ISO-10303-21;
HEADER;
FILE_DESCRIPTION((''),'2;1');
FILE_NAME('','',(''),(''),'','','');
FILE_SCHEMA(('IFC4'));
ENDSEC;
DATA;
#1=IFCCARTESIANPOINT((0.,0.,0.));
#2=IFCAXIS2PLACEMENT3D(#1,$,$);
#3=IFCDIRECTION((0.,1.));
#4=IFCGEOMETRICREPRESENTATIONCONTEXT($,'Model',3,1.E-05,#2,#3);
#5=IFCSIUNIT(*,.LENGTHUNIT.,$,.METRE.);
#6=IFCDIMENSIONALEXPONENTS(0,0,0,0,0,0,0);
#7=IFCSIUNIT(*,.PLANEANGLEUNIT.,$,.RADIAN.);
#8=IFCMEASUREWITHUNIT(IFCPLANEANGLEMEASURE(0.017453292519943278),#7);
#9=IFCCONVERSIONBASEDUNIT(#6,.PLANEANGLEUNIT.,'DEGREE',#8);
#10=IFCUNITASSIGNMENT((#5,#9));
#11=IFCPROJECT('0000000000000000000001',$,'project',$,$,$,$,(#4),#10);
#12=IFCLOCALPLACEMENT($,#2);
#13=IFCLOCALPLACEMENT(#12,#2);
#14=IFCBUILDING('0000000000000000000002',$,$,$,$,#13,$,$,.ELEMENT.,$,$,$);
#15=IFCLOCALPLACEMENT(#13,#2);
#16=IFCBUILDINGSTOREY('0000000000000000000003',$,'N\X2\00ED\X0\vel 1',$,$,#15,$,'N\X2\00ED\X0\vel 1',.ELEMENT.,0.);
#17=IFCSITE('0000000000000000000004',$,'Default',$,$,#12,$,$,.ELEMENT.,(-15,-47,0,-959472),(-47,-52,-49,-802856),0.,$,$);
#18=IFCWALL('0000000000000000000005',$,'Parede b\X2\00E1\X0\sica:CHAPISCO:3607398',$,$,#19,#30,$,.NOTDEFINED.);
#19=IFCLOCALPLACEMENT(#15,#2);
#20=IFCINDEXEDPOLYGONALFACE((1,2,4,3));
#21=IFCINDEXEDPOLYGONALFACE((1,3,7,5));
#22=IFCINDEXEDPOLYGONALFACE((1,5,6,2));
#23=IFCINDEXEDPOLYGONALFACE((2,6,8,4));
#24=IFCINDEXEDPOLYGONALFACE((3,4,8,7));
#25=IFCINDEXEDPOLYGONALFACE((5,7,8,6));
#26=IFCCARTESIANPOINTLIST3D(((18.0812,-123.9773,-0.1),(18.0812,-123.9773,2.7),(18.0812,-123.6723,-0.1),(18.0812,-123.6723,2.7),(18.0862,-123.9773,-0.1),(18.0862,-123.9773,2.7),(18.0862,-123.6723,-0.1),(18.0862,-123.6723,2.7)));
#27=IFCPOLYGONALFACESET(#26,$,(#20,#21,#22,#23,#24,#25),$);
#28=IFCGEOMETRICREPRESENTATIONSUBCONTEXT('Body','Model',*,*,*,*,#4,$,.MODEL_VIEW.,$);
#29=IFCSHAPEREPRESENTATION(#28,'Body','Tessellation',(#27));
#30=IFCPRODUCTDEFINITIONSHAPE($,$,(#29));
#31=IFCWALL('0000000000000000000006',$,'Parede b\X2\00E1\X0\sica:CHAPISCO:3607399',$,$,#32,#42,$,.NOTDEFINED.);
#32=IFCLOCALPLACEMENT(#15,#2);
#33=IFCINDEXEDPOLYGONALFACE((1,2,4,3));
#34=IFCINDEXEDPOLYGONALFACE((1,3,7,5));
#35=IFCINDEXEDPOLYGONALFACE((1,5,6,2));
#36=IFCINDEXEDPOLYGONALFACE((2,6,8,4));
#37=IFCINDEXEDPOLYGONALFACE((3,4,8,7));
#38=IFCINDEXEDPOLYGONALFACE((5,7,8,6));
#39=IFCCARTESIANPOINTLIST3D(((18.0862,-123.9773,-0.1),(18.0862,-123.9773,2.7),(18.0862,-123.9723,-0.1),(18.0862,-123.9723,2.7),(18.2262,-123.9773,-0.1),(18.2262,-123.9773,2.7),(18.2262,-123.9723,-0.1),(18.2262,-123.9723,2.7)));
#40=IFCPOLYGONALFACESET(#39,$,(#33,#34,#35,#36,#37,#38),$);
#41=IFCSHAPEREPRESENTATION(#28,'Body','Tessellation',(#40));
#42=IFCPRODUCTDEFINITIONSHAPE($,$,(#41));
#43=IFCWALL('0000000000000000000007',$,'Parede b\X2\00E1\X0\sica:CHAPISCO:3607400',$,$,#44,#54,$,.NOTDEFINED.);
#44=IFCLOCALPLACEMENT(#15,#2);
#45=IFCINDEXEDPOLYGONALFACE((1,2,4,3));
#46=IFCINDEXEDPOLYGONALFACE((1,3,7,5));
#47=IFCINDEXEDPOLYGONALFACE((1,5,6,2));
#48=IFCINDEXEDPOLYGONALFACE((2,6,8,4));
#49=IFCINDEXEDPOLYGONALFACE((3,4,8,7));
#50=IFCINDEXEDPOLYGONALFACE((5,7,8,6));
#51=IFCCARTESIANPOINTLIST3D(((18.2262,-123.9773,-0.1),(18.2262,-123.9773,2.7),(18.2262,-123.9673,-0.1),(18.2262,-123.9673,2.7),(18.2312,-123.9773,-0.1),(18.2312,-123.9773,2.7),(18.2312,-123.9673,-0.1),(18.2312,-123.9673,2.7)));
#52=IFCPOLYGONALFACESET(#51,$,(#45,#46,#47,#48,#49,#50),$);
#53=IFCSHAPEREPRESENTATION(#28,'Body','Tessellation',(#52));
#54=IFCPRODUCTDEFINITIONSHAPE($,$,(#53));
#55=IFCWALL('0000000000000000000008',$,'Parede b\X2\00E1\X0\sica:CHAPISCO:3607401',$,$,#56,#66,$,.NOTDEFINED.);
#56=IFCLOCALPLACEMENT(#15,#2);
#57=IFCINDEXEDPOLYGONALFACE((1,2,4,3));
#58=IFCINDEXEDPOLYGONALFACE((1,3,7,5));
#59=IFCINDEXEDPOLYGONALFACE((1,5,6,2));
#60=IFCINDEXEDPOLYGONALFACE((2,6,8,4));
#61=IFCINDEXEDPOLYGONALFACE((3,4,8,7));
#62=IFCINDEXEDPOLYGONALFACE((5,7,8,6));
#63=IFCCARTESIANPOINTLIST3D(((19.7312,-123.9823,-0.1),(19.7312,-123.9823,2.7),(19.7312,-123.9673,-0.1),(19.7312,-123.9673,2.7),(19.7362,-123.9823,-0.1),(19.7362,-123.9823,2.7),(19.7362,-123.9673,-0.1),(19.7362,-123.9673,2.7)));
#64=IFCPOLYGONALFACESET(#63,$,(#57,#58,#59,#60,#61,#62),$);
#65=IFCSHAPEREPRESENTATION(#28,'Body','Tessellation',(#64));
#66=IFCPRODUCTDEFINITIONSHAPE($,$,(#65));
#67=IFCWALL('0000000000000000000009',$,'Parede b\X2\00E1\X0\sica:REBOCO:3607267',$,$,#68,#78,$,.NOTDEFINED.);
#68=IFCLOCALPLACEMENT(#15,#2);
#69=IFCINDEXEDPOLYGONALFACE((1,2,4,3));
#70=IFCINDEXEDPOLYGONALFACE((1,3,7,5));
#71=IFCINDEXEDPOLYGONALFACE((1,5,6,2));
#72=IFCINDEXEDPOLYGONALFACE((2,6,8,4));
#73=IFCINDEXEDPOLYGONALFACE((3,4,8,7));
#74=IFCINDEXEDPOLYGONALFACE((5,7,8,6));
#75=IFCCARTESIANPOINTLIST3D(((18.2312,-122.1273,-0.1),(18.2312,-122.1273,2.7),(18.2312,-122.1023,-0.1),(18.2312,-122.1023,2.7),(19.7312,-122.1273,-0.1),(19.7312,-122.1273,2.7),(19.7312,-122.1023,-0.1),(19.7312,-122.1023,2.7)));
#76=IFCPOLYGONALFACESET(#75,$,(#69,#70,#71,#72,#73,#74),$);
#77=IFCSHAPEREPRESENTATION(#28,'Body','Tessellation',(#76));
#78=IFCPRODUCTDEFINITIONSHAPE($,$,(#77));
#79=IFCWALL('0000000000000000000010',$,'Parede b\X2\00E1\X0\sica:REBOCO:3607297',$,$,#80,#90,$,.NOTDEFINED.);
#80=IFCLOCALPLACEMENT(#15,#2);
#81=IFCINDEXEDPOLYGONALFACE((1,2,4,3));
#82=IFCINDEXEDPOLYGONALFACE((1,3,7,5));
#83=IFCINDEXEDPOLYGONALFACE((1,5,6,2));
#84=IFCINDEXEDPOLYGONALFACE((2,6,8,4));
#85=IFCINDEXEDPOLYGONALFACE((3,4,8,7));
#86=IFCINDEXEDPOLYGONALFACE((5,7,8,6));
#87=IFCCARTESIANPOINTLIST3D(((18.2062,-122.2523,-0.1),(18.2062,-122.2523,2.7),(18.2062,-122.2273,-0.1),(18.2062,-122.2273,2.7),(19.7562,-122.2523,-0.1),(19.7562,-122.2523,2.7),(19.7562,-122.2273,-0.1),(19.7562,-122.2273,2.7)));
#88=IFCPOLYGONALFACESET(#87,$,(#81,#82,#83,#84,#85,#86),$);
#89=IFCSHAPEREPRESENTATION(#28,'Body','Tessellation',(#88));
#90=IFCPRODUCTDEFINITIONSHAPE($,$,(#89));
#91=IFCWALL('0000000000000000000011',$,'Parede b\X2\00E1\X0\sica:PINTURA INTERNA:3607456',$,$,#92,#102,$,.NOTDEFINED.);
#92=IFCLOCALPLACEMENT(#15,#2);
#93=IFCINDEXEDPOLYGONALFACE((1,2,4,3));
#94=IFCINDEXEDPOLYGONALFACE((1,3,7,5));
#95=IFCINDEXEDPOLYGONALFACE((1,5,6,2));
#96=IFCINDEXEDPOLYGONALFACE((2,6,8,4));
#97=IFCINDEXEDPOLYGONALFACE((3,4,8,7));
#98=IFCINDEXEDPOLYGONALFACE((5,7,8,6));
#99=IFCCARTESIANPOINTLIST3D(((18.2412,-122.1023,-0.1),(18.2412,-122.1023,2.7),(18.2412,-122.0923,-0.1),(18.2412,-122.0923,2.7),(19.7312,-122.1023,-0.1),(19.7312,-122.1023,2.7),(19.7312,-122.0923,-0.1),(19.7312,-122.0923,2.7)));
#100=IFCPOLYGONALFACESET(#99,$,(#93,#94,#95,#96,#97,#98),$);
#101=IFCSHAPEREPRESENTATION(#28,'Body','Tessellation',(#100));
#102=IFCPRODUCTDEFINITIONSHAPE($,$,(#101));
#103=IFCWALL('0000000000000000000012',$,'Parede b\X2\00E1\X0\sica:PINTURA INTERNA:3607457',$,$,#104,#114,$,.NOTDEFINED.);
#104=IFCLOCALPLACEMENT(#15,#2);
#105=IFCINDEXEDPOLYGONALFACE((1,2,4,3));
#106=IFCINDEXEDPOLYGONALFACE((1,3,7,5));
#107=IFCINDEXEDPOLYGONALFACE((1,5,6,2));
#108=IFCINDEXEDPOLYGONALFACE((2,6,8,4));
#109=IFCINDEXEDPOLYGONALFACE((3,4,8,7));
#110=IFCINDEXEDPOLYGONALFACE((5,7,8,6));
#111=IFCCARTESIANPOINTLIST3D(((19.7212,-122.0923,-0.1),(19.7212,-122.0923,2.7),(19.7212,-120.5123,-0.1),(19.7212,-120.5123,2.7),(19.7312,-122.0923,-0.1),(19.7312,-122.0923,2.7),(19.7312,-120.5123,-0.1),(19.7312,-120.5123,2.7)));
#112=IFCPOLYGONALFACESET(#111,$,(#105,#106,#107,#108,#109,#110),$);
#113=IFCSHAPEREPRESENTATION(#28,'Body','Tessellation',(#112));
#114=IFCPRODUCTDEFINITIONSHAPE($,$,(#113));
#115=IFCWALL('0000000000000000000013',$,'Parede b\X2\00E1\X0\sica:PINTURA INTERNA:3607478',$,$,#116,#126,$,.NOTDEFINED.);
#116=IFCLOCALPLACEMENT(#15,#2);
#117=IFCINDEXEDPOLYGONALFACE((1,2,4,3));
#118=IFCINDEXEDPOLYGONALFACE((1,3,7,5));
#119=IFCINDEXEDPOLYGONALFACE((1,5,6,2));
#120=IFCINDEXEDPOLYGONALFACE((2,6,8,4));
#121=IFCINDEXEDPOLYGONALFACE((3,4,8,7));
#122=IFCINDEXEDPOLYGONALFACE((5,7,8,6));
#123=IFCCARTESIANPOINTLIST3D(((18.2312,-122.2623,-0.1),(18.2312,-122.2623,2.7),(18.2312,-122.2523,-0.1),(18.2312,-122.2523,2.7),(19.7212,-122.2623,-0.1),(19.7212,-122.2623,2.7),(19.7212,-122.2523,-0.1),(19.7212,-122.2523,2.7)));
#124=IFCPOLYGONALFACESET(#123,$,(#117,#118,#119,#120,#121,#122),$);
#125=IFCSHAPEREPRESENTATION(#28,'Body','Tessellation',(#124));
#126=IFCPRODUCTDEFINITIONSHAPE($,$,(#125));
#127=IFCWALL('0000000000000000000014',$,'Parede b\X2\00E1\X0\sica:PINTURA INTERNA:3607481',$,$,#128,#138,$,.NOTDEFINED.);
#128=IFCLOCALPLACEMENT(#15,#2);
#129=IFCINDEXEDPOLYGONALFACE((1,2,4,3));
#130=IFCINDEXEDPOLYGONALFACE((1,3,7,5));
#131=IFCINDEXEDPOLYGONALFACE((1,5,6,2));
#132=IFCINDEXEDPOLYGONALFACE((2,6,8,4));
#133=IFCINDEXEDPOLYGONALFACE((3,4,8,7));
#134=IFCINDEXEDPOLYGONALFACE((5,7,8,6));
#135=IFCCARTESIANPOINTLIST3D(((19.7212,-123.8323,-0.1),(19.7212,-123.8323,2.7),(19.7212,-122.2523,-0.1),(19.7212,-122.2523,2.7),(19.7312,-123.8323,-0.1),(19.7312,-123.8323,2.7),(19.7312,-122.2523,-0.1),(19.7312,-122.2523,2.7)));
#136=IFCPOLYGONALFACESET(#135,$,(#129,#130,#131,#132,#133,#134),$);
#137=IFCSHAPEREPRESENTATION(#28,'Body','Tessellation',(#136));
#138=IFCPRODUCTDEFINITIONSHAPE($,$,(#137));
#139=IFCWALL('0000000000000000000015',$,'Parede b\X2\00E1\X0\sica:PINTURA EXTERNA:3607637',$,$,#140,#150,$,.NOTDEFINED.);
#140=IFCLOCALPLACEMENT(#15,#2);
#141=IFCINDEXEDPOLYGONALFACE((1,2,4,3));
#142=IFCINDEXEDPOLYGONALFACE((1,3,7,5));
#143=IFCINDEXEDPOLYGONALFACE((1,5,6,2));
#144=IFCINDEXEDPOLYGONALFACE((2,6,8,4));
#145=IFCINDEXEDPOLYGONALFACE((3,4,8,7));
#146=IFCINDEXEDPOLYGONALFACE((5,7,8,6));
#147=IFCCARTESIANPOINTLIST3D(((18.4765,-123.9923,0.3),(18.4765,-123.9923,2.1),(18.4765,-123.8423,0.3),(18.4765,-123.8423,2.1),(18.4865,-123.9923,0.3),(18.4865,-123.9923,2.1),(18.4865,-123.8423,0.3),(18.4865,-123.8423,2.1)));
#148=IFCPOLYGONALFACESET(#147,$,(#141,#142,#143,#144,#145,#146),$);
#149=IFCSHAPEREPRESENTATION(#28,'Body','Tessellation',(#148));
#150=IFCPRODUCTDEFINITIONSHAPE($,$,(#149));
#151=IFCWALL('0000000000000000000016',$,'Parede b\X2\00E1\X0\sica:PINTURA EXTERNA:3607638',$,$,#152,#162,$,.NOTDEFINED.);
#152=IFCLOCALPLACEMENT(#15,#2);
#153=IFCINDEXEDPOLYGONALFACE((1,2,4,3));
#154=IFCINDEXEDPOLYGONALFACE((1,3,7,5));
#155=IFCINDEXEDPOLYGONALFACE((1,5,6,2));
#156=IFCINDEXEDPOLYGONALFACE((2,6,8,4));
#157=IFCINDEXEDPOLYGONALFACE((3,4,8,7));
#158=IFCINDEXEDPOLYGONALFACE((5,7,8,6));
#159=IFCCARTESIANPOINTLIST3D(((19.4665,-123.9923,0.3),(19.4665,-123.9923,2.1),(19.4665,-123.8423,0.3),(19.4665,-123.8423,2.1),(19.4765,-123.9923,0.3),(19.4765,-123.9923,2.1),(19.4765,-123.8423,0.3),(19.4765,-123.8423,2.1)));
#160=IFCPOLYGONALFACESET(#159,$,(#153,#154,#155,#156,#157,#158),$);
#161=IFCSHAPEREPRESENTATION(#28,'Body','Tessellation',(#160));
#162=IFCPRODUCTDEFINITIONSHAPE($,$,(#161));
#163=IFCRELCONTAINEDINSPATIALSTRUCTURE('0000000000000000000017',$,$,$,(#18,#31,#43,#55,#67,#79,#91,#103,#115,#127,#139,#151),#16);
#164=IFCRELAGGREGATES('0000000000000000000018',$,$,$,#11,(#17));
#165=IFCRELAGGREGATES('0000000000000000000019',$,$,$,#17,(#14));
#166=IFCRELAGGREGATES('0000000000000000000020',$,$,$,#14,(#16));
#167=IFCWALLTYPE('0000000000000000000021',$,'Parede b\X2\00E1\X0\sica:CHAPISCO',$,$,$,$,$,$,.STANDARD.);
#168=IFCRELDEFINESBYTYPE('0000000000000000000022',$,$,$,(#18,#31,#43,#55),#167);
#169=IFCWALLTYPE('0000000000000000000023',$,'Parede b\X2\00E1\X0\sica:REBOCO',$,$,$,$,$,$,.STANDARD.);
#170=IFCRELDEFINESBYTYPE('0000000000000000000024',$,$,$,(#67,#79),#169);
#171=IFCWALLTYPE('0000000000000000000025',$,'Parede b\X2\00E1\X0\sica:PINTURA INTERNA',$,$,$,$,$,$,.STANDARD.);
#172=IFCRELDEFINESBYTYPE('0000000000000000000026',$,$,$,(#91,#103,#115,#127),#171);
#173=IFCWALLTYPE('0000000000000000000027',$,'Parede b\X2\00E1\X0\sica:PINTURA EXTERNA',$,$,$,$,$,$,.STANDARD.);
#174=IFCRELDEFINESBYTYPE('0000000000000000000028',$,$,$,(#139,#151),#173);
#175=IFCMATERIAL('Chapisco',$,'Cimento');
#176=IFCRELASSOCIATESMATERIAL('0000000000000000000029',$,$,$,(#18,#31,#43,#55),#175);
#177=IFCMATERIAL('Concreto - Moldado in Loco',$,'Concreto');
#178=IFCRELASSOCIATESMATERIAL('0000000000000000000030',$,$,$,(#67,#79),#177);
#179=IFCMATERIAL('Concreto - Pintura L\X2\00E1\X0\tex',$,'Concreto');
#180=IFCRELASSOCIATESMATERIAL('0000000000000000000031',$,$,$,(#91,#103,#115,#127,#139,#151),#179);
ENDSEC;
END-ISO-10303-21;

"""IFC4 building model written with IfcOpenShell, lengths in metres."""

from ifc_helpers import new_model, entity, si_unit, converted_unit, direction, frame, origin, place, context, subcontext, project, spatial, indexed_curve, outline, extrude, material, type_object, element, save


model = new_model("IFC4")

# Units and contexts
model_context = context("Model", 3, precision=1e-05, world=origin(), true_north=direction((0.0, 1.0)))
body_context = subcontext(model_context, "Body", "Model", "MODEL_VIEW")
ifc_project = project(units=[si_unit("LENGTHUNIT", "METRE"), converted_unit("PLANEANGLEUNIT", "DEGREE", entity("IfcPlaneAngleMeasure", 0.017453292519943278), si_unit("PLANEANGLEUNIT", "RADIAN"), dimensions=[0, 0, 0, 0, 0, 0, 0])], contexts=[model_context])

# Site, building, storey
site_placement = place(None, origin())
site = spatial("IfcSite", under=ifc_project, at=site_placement, Name="Default", CompositionType="ELEMENT", RefLatitude=(-15, -47, 0, -959472), RefLongitude=(-47, -52, -49, -802856), RefElevation=0.0)
building_placement = place(site_placement, origin())
building = spatial("IfcBuilding", under=site, at=building_placement, CompositionType="ELEMENT")
storey_placement = place(building_placement, origin())
storey = spatial("IfcBuildingStorey", under=building, at=storey_placement, Name="Nível 1", LongName="Nível 1", CompositionType="ELEMENT", Elevation=0.0)

# Walls
ifc_material_1 = material(Name="Chapisco", Category="Cimento")
wall_type_1 = type_object("IfcWallType", Name="Parede básica:CHAPISCO", PredefinedType="STANDARD")
wall_1_placement = place(storey_placement, frame((18.0837, -123.6723, -0.1), z_axis=(0.0, 0.0, 1.0), x_axis=(0.0, -1.0, 0.0)))
element("IfcWall", 1, at=wall_1_placement, inside=storey, type_object=wall_type_1, material=ifc_material_1, Name="Parede básica:CHAPISCO:3607398", PredefinedType="NOTDEFINED", context=body_context, shape_type="SweptSolid", body=[
    extrude(outline(indexed_curve([(0.305, 0.0025), (0.0, 0.0025), (0.0, -0.0025), (0.305, -0.0025), (0.305, 0.0025)], self_intersect=False)), origin(), (0.0, 0.0, 1.0), 2.8),
])
wall_2_placement = place(storey_placement, frame((18.0862, -123.9748, -0.1)))
element("IfcWall", 2, at=wall_2_placement, inside=storey, type_object=wall_type_1, material=ifc_material_1, Name="Parede básica:CHAPISCO:3607399", PredefinedType="NOTDEFINED", context=body_context, shape_type="SweptSolid", body=[
    extrude(outline(indexed_curve([(0.14, 0.0025), (0.0, 0.0025), (0.0, -0.0025), (0.14, -0.0025), (0.14, 0.0025)], self_intersect=False)), origin(), (0.0, 0.0, 1.0), 2.8),
])
wall_3_placement = place(storey_placement, frame((18.2287, -123.9773, -0.1), z_axis=(0.0, 0.0, 1.0), x_axis=(0.0, 1.0, 0.0)))
element("IfcWall", 3, at=wall_3_placement, inside=storey, type_object=wall_type_1, material=ifc_material_1, Name="Parede básica:CHAPISCO:3607400", PredefinedType="NOTDEFINED", context=body_context, shape_type="SweptSolid", body=[
    extrude(outline(indexed_curve([(0.01, 0.0025), (0.0, 0.0025), (0.0, -0.0025), (0.01, -0.0025), (0.01, 0.0025)], self_intersect=False)), origin(), (0.0, 0.0, 1.0), 2.8),
])
wall_4_placement = place(storey_placement, frame((19.7337, -123.9673, -0.1), z_axis=(0.0, 0.0, 1.0), x_axis=(0.0, -1.0, 0.0)))
element("IfcWall", 4, at=wall_4_placement, inside=storey, type_object=wall_type_1, material=ifc_material_1, Name="Parede básica:CHAPISCO:3607401", PredefinedType="NOTDEFINED", context=body_context, shape_type="SweptSolid", body=[
    extrude(outline(indexed_curve([(0.015, 0.0025), (0.0, 0.0025), (0.0, -0.0025), (0.015, -0.0025), (0.015, 0.0025)], self_intersect=False)), origin(), (0.0, 0.0, 1.0), 2.8),
])
ifc_material_2 = material(Name="Concreto - Moldado in Loco", Category="Concreto")
wall_type_2 = type_object("IfcWallType", Name="Parede básica:REBOCO", PredefinedType="STANDARD")
wall_5_placement = place(storey_placement, frame((19.7312, -122.1148, -0.1), z_axis=(0.0, 0.0, 1.0), x_axis=(-1.0, 0.0, 0.0)))
element("IfcWall", 5, at=wall_5_placement, inside=storey, type_object=wall_type_2, material=ifc_material_2, Name="Parede básica:REBOCO:3607267", PredefinedType="NOTDEFINED", context=body_context, shape_type="SweptSolid", body=[
    extrude(outline(indexed_curve([(1.5, 0.0125), (0.0, 0.0125), (0.0, -0.0125), (1.5, -0.0125), (1.5, 0.0125)], self_intersect=False)), origin(), (0.0, 0.0, 1.0), 2.8),
])
wall_6_placement = place(storey_placement, frame((18.2062, -122.2398, -0.1)))
element("IfcWall", 6, at=wall_6_placement, inside=storey, type_object=wall_type_2, material=ifc_material_2, Name="Parede básica:REBOCO:3607297", PredefinedType="NOTDEFINED", context=body_context, shape_type="SweptSolid", body=[
    extrude(outline(indexed_curve([(1.55, 0.0125), (0.0, 0.0125), (0.0, -0.0125), (1.55, -0.0125), (1.55, 0.0125)], self_intersect=False)), origin(), (0.0, 0.0, 1.0), 2.8),
])
ifc_material_3 = material(Name="Concreto - Pintura Látex", Category="Concreto")
wall_type_3 = type_object("IfcWallType", Name="Parede básica:PINTURA INTERNA", PredefinedType="STANDARD")
wall_7_placement = place(storey_placement, frame((19.7312, -122.0973, -0.1), z_axis=(0.0, 0.0, 1.0), x_axis=(-1.0, 0.0, 0.0)))
element("IfcWall", 7, at=wall_7_placement, inside=storey, type_object=wall_type_3, material=ifc_material_3, Name="Parede básica:PINTURA INTERNA:3607456", PredefinedType="NOTDEFINED", context=body_context, shape_type="SweptSolid", body=[
    extrude(outline(indexed_curve([(1.49, 0.005), (0.0, 0.005), (0.0, -0.005), (1.49, -0.005), (1.49, 0.005)], self_intersect=False)), origin(), (0.0, 0.0, 1.0), 2.8),
])
wall_8_placement = place(storey_placement, frame((19.7262, -120.5123, -0.1), z_axis=(0.0, 0.0, 1.0), x_axis=(0.0, -1.0, 0.0)))
element("IfcWall", 8, at=wall_8_placement, inside=storey, type_object=wall_type_3, material=ifc_material_3, Name="Parede básica:PINTURA INTERNA:3607457", PredefinedType="NOTDEFINED", context=body_context, shape_type="SweptSolid", body=[
    extrude(outline(indexed_curve([(1.58, 0.005), (0.0, 0.005), (0.0, -0.005), (1.58, -0.005), (1.58, 0.005)], self_intersect=False)), origin(), (0.0, 0.0, 1.0), 2.8),
])
wall_9_placement = place(storey_placement, frame((18.2312, -122.2573, -0.1)))
element("IfcWall", 9, at=wall_9_placement, inside=storey, type_object=wall_type_3, material=ifc_material_3, Name="Parede básica:PINTURA INTERNA:3607478", PredefinedType="NOTDEFINED", context=body_context, shape_type="SweptSolid", body=[
    extrude(outline(indexed_curve([(1.49, 0.005), (0.0, 0.005), (0.0, -0.005), (1.49, -0.005), (1.49, 0.005)], self_intersect=False)), origin(), (0.0, 0.0, 1.0), 2.8),
])
wall_10_placement = place(storey_placement, frame((19.7262, -122.2523, -0.1), z_axis=(0.0, 0.0, 1.0), x_axis=(0.0, -1.0, 0.0)))
element("IfcWall", 10, at=wall_10_placement, inside=storey, type_object=wall_type_3, material=ifc_material_3, Name="Parede básica:PINTURA INTERNA:3607481", PredefinedType="NOTDEFINED", context=body_context, shape_type="SweptSolid", body=[
    extrude(outline(indexed_curve([(1.58, 0.005), (0.0, 0.005), (0.0, -0.005), (1.58, -0.005), (1.58, 0.005)], self_intersect=False)), origin(), (0.0, 0.0, 1.0), 2.8),
])
wall_type_4 = type_object("IfcWallType", Name="Parede básica:PINTURA EXTERNA", PredefinedType="STANDARD")
for number, where, z_axis, x_axis, name in (
    (11, (18.4815, -123.8423, 0.3), (0.0, 0.0, 1.0), (0.0, -1.0, 0.0), "Parede básica:PINTURA EXTERNA:3607637"),
    (12, (19.4715, -123.8423, 0.3), (0.0, 0.0, 1.0), (0.0, -1.0, 0.0), "Parede básica:PINTURA EXTERNA:3607638"),
):
    element("IfcWall", number, at=place(storey_placement, frame(where, z_axis=z_axis, x_axis=x_axis)), inside=storey, type_object=wall_type_4, material=ifc_material_3, Name=name, PredefinedType="NOTDEFINED", context=body_context, shape_type="SweptSolid", body=[
        extrude(outline(indexed_curve([(0.15, 0.005), (0.0, 0.005), (0.0, -0.005), (0.15, -0.005), (0.15, 0.005)], self_intersect=False)), origin(), (0.0, 0.0, 1.0), 1.8),
    ])

save(model, "model.ifc")
